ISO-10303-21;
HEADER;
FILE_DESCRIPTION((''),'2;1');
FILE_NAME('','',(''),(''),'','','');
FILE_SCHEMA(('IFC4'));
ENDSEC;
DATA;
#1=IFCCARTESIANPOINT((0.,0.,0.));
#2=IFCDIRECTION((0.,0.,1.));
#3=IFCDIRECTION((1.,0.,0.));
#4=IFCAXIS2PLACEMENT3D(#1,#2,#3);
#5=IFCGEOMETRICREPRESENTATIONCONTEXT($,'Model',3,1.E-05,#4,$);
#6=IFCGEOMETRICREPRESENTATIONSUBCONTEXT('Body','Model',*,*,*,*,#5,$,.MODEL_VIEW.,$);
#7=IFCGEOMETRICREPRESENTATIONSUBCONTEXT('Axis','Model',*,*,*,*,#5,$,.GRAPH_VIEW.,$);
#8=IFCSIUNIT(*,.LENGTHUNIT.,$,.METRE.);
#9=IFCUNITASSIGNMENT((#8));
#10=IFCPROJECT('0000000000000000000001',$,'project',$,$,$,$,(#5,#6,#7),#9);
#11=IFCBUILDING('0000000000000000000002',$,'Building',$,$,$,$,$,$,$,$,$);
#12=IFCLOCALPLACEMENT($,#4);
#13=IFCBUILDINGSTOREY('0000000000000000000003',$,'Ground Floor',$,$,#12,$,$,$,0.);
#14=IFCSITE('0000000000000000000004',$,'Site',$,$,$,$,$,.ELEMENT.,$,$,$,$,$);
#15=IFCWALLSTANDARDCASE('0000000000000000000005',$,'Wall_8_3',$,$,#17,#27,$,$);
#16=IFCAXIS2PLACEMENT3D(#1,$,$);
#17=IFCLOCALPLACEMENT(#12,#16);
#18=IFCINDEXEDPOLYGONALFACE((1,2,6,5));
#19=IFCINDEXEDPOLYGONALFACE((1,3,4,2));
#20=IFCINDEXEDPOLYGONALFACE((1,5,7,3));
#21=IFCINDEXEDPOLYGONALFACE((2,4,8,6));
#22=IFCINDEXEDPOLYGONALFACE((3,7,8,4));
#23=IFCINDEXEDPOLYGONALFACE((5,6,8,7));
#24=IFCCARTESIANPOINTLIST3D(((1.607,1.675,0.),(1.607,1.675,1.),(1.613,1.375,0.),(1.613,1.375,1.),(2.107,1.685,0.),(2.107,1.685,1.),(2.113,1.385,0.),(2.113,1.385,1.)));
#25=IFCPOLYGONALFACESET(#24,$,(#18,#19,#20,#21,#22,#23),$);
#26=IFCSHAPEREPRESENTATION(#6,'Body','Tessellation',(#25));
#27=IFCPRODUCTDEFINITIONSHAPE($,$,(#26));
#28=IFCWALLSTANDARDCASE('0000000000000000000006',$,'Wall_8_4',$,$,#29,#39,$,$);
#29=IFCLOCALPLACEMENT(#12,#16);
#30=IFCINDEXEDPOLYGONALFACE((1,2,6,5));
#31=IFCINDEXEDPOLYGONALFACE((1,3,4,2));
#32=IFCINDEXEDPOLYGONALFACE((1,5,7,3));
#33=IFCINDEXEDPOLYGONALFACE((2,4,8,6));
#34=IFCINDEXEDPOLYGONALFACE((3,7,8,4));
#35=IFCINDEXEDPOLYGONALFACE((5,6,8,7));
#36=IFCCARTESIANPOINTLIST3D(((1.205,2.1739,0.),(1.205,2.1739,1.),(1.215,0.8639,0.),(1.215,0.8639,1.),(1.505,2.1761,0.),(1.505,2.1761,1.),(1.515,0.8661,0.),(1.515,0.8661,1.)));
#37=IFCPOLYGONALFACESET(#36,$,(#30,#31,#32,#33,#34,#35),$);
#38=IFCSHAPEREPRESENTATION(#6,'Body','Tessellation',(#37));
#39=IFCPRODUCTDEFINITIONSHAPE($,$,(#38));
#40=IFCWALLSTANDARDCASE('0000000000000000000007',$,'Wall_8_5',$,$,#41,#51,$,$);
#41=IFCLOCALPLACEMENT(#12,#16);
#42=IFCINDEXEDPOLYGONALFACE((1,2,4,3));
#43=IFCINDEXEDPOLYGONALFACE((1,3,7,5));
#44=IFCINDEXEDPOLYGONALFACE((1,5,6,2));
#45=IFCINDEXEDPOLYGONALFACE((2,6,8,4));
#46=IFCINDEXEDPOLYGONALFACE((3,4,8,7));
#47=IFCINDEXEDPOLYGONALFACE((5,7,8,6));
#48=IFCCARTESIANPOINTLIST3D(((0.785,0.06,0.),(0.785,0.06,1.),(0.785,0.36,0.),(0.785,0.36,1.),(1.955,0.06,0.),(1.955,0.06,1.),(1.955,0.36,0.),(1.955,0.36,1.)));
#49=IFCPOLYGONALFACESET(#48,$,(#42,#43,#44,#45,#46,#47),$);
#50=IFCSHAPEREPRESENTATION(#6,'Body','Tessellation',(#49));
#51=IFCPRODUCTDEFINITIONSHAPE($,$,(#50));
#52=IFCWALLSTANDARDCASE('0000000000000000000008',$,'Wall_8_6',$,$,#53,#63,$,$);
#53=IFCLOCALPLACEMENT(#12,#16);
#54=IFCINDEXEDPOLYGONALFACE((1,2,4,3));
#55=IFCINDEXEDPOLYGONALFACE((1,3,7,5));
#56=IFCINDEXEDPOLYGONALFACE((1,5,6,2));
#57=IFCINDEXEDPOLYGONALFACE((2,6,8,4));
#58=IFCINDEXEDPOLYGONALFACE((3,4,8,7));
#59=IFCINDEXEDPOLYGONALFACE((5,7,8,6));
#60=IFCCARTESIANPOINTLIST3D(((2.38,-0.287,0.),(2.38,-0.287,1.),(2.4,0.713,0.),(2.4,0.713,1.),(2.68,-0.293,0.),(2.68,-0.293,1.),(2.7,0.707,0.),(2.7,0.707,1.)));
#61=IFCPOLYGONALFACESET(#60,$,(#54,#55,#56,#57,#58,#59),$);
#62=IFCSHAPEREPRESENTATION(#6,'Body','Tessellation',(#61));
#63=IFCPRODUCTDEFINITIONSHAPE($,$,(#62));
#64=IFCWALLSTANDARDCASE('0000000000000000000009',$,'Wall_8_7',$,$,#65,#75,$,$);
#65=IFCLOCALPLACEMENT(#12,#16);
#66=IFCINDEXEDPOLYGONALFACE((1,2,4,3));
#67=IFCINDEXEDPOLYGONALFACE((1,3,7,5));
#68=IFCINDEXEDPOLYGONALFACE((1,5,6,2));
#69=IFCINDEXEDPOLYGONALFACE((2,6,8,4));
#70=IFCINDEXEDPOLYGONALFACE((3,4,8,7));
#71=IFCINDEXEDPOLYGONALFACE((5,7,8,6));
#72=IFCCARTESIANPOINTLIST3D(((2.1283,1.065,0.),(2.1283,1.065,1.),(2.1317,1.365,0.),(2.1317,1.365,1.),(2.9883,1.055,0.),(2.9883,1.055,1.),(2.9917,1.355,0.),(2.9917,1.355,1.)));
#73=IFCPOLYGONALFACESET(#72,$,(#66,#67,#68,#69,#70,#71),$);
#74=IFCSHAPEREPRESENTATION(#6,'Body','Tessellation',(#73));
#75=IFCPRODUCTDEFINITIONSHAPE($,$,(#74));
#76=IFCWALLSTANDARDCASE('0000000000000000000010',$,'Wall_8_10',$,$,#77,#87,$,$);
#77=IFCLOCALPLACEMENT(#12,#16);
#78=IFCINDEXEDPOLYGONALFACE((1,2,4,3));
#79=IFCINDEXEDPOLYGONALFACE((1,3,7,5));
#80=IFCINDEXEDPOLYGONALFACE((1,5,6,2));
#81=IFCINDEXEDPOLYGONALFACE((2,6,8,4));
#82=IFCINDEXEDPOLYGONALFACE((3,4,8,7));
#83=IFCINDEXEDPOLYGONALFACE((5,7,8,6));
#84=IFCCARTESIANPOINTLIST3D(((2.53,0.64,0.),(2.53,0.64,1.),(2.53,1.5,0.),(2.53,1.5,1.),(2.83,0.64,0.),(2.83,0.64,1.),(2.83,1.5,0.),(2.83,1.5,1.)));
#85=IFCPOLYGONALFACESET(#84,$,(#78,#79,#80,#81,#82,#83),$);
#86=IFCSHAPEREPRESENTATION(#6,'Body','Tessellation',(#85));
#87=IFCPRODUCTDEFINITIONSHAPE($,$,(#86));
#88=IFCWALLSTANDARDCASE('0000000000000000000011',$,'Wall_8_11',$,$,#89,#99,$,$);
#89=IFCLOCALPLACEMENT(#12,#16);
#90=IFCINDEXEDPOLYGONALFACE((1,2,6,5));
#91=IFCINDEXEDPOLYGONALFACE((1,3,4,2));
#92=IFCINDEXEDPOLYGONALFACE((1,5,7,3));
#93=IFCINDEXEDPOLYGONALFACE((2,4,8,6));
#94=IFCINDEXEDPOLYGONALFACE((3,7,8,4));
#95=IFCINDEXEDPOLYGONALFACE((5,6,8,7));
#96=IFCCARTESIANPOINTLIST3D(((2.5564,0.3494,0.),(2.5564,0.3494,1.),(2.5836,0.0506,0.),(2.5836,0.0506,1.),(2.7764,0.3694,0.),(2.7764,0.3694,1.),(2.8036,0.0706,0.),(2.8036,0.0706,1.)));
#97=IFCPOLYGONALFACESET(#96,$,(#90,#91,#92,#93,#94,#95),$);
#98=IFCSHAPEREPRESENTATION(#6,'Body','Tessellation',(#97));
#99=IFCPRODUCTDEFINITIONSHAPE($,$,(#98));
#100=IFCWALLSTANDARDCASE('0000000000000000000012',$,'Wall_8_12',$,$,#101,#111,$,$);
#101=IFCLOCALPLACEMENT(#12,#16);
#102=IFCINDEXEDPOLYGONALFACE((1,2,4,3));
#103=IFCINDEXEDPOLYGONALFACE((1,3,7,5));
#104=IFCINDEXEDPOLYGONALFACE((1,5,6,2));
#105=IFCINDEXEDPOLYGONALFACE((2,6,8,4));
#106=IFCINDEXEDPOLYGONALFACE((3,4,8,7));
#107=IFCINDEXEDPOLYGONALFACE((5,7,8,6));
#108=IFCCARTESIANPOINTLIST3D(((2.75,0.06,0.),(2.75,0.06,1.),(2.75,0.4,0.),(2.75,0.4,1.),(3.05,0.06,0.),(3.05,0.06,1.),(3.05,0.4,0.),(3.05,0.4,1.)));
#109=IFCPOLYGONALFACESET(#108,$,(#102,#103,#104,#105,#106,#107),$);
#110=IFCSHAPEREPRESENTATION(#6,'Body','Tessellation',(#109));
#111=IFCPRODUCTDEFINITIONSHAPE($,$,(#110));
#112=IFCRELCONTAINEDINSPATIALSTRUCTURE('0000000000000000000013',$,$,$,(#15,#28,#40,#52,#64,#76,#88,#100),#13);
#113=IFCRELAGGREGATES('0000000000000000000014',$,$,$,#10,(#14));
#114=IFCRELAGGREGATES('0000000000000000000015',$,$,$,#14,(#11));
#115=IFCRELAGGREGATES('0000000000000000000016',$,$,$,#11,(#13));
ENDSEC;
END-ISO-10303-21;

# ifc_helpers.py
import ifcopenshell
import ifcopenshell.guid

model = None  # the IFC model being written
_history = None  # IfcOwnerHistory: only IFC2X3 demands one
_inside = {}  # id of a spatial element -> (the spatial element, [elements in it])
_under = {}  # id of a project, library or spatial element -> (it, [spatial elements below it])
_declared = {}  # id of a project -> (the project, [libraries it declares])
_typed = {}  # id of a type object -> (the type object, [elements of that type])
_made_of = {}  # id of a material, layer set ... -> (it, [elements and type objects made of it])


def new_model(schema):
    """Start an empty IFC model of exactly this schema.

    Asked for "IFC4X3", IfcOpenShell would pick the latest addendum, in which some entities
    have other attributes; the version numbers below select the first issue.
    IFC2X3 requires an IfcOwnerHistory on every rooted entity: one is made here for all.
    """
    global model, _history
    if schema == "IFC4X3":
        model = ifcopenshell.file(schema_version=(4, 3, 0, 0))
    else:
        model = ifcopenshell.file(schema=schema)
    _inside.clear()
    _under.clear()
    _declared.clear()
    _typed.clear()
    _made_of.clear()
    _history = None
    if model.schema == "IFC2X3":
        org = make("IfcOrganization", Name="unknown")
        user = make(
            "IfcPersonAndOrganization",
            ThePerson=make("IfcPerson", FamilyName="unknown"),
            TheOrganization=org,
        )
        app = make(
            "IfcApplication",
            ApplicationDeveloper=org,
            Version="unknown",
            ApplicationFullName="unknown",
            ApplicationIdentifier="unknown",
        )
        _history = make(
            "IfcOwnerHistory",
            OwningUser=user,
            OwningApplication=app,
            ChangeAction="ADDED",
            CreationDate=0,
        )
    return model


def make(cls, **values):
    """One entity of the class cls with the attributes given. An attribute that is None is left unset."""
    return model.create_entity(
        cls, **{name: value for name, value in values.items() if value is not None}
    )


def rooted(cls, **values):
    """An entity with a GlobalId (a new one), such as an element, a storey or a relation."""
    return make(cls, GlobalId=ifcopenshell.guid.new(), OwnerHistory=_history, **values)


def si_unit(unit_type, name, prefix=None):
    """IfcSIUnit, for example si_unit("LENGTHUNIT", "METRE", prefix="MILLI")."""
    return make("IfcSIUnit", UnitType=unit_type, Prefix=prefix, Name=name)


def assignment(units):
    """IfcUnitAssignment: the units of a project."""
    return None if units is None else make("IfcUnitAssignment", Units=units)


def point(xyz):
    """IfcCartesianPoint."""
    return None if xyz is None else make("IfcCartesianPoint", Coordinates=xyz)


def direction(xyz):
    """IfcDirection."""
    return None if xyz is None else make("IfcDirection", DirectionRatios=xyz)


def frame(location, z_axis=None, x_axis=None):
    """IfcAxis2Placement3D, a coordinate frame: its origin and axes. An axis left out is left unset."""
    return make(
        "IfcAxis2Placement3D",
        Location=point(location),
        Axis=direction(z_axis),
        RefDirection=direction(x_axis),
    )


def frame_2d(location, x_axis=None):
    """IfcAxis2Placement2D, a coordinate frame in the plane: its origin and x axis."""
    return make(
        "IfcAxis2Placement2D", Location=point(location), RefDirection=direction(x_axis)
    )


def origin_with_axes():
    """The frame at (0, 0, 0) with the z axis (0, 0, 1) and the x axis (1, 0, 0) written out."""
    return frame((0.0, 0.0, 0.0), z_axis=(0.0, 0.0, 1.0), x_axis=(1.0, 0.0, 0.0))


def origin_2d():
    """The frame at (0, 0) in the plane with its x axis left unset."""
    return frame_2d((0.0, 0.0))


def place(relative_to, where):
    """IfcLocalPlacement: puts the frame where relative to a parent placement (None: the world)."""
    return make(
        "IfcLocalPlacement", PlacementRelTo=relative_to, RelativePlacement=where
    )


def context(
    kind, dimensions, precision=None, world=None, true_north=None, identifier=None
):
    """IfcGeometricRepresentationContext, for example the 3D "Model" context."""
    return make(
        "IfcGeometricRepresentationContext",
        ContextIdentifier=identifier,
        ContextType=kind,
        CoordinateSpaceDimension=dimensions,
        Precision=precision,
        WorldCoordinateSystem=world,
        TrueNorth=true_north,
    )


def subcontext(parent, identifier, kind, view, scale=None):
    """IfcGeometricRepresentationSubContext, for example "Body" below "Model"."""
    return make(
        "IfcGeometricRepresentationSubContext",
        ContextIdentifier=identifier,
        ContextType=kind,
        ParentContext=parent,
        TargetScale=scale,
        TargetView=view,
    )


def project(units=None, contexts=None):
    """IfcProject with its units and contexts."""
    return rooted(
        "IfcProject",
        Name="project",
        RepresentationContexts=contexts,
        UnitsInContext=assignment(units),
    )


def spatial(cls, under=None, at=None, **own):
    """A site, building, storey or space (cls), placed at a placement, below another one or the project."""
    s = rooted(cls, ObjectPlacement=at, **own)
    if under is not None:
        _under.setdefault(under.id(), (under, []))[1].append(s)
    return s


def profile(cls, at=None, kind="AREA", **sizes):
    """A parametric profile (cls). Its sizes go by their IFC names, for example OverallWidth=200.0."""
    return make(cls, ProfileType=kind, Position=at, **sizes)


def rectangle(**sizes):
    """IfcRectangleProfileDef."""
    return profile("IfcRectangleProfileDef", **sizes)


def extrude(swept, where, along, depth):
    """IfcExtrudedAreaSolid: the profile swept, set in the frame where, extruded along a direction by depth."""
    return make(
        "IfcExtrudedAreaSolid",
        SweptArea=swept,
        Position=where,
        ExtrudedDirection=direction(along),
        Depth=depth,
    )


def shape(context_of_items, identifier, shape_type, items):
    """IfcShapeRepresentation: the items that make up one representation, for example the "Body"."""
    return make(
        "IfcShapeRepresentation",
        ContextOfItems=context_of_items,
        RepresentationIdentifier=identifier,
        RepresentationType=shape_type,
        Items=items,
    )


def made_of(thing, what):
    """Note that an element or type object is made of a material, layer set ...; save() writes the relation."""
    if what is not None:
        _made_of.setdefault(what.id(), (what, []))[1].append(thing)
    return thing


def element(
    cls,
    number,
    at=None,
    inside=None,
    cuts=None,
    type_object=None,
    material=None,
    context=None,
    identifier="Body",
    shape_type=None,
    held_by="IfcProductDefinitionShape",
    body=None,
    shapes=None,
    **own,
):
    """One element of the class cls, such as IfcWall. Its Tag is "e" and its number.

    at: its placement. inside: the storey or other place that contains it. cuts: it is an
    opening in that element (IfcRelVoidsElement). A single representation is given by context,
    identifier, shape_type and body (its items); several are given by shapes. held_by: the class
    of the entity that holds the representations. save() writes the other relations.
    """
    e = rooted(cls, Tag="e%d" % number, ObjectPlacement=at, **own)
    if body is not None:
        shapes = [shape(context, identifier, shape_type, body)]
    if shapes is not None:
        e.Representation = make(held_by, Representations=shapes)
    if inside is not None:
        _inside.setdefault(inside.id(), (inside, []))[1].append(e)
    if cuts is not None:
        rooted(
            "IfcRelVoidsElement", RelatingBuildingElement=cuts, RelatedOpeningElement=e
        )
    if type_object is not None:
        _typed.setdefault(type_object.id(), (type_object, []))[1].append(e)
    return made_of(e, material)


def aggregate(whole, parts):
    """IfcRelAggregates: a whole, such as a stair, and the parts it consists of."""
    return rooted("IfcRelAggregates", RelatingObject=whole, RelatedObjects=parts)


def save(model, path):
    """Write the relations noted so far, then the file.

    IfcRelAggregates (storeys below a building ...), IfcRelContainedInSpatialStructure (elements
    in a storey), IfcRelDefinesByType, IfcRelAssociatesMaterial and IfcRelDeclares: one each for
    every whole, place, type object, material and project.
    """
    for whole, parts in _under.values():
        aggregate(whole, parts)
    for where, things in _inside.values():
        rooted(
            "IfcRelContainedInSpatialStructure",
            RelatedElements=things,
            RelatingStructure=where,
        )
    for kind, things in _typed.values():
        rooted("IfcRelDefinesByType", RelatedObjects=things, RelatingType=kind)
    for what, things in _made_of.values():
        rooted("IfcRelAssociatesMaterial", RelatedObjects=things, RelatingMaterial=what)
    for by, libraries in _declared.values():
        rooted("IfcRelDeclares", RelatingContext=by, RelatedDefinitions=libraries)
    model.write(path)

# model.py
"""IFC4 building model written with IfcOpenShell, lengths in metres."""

from ifc_helpers import new_model, si_unit, frame, origin_with_axes, origin_2d, place, context, subcontext, project, spatial, rectangle, extrude, element, save


model = new_model("IFC4")

# Units and contexts
model_context = context("Model", 3, precision=1e-05, world=origin_with_axes())
body_context = subcontext(model_context, "Body", "Model", "MODEL_VIEW")
axis_context = subcontext(model_context, "Axis", "Model", "GRAPH_VIEW")
ifc_project = project(units=[si_unit("LENGTHUNIT", "METRE")], contexts=[model_context, body_context, axis_context])

# Site, building, storey
site = spatial("IfcSite", under=ifc_project, Name="Site", CompositionType="ELEMENT")
building = spatial("IfcBuilding", under=site, Name="Building")
storey_placement = place(None, origin_with_axes())
storey = spatial("IfcBuildingStorey", under=building, at=storey_placement, Name="Ground Floor", Elevation=0.0)

# Walls
wall_1_placement = place(storey_placement, frame((1.86, 1.53, 0.0), z_axis=(0.0, 0.0, 1.0), x_axis=(-0.9998, -0.019996, 0.0)))
element("IfcWallStandardCase", 1, at=wall_1_placement, inside=storey, Name="Wall_8_3", context=body_context, shape_type="SweptSolid", body=[
    extrude(rectangle(XDim=0.5001, YDim=0.3, at=origin_2d()), origin_with_axes(), (0.0, 0.0, 1.0), 1.0),
])
wall_2_placement = place(storey_placement, frame((1.36, 1.52, 0.0), z_axis=(0.0, 0.0, 1.0), x_axis=(0.007633, -0.999971, 0.0)))
element("IfcWallStandardCase", 2, at=wall_2_placement, inside=storey, Name="Wall_8_4", context=body_context, shape_type="SweptSolid", body=[
    extrude(rectangle(XDim=1.31, YDim=0.3, at=origin_2d()), origin_with_axes(), (0.0, 0.0, 1.0), 1.0),
])
wall_3_placement = place(storey_placement, frame((1.37, 0.21, 0.0), z_axis=(0.0, 0.0, 1.0), x_axis=(1.0, 0.0, 0.0)))
element("IfcWallStandardCase", 3, at=wall_3_placement, inside=storey, Name="Wall_8_5", context=body_context, shape_type="SweptSolid", body=[
    extrude(rectangle(XDim=1.17, YDim=0.3, at=origin_2d()), origin_with_axes(), (0.0, 0.0, 1.0), 1.0),
])
wall_4_placement = place(storey_placement, frame((2.54, 0.21, 0.0), z_axis=(0.0, 0.0, 1.0), x_axis=(0.019996, 0.9998, 0.0)))
element("IfcWallStandardCase", 4, at=wall_4_placement, inside=storey, Name="Wall_8_6", context=body_context, shape_type="SweptSolid", body=[
    extrude(rectangle(XDim=1.0002, YDim=0.3, at=origin_2d()), origin_with_axes(), (0.0, 0.0, 1.0), 1.0),
])
wall_5_placement = place(storey_placement, frame((2.56, 1.21, 0.0), z_axis=(0.0, 0.0, 1.0), x_axis=(0.999932, -0.011627, 0.0)))
element("IfcWallStandardCase", 5, at=wall_5_placement, inside=storey, Name="Wall_8_7", context=body_context, shape_type="SweptSolid", body=[
    extrude(rectangle(XDim=0.8601, YDim=0.3, at=origin_2d()), origin_with_axes(), (0.0, 0.0, 1.0), 1.0),
])
wall_6_placement = place(storey_placement, frame((2.68, 1.07, 0.0), z_axis=(0.0, 0.0, 1.0), x_axis=(0.0, -1.0, 0.0)))
element("IfcWallStandardCase", 6, at=wall_6_placement, inside=storey, Name="Wall_8_10", context=body_context, shape_type="SweptSolid", body=[
    extrude(rectangle(XDim=0.86, YDim=0.3, at=origin_2d()), origin_with_axes(), (0.0, 0.0, 1.0), 1.0),
])
wall_7_placement = place(storey_placement, frame((2.68, 0.21, 0.0), z_axis=(0.0, 0.0, 1.0), x_axis=(0.995893, 0.090536, 0.0)))
element("IfcWallStandardCase", 7, at=wall_7_placement, inside=storey, Name="Wall_8_11", context=body_context, shape_type="SweptSolid", body=[
    extrude(rectangle(XDim=0.2209, YDim=0.3, at=origin_2d()), origin_with_axes(), (0.0, 0.0, 1.0), 1.0),
])
wall_8_placement = place(storey_placement, frame((2.9, 0.23, 0.0), z_axis=(0.0, 0.0, 1.0), x_axis=(0.0, 1.0, 0.0)))
element("IfcWallStandardCase", 8, at=wall_8_placement, inside=storey, Name="Wall_8_12", context=body_context, shape_type="SweptSolid", body=[
    extrude(rectangle(XDim=0.34, YDim=0.3, at=origin_2d()), origin_with_axes(), (0.0, 0.0, 1.0), 1.0),
])

save(model, "model.ifc")
